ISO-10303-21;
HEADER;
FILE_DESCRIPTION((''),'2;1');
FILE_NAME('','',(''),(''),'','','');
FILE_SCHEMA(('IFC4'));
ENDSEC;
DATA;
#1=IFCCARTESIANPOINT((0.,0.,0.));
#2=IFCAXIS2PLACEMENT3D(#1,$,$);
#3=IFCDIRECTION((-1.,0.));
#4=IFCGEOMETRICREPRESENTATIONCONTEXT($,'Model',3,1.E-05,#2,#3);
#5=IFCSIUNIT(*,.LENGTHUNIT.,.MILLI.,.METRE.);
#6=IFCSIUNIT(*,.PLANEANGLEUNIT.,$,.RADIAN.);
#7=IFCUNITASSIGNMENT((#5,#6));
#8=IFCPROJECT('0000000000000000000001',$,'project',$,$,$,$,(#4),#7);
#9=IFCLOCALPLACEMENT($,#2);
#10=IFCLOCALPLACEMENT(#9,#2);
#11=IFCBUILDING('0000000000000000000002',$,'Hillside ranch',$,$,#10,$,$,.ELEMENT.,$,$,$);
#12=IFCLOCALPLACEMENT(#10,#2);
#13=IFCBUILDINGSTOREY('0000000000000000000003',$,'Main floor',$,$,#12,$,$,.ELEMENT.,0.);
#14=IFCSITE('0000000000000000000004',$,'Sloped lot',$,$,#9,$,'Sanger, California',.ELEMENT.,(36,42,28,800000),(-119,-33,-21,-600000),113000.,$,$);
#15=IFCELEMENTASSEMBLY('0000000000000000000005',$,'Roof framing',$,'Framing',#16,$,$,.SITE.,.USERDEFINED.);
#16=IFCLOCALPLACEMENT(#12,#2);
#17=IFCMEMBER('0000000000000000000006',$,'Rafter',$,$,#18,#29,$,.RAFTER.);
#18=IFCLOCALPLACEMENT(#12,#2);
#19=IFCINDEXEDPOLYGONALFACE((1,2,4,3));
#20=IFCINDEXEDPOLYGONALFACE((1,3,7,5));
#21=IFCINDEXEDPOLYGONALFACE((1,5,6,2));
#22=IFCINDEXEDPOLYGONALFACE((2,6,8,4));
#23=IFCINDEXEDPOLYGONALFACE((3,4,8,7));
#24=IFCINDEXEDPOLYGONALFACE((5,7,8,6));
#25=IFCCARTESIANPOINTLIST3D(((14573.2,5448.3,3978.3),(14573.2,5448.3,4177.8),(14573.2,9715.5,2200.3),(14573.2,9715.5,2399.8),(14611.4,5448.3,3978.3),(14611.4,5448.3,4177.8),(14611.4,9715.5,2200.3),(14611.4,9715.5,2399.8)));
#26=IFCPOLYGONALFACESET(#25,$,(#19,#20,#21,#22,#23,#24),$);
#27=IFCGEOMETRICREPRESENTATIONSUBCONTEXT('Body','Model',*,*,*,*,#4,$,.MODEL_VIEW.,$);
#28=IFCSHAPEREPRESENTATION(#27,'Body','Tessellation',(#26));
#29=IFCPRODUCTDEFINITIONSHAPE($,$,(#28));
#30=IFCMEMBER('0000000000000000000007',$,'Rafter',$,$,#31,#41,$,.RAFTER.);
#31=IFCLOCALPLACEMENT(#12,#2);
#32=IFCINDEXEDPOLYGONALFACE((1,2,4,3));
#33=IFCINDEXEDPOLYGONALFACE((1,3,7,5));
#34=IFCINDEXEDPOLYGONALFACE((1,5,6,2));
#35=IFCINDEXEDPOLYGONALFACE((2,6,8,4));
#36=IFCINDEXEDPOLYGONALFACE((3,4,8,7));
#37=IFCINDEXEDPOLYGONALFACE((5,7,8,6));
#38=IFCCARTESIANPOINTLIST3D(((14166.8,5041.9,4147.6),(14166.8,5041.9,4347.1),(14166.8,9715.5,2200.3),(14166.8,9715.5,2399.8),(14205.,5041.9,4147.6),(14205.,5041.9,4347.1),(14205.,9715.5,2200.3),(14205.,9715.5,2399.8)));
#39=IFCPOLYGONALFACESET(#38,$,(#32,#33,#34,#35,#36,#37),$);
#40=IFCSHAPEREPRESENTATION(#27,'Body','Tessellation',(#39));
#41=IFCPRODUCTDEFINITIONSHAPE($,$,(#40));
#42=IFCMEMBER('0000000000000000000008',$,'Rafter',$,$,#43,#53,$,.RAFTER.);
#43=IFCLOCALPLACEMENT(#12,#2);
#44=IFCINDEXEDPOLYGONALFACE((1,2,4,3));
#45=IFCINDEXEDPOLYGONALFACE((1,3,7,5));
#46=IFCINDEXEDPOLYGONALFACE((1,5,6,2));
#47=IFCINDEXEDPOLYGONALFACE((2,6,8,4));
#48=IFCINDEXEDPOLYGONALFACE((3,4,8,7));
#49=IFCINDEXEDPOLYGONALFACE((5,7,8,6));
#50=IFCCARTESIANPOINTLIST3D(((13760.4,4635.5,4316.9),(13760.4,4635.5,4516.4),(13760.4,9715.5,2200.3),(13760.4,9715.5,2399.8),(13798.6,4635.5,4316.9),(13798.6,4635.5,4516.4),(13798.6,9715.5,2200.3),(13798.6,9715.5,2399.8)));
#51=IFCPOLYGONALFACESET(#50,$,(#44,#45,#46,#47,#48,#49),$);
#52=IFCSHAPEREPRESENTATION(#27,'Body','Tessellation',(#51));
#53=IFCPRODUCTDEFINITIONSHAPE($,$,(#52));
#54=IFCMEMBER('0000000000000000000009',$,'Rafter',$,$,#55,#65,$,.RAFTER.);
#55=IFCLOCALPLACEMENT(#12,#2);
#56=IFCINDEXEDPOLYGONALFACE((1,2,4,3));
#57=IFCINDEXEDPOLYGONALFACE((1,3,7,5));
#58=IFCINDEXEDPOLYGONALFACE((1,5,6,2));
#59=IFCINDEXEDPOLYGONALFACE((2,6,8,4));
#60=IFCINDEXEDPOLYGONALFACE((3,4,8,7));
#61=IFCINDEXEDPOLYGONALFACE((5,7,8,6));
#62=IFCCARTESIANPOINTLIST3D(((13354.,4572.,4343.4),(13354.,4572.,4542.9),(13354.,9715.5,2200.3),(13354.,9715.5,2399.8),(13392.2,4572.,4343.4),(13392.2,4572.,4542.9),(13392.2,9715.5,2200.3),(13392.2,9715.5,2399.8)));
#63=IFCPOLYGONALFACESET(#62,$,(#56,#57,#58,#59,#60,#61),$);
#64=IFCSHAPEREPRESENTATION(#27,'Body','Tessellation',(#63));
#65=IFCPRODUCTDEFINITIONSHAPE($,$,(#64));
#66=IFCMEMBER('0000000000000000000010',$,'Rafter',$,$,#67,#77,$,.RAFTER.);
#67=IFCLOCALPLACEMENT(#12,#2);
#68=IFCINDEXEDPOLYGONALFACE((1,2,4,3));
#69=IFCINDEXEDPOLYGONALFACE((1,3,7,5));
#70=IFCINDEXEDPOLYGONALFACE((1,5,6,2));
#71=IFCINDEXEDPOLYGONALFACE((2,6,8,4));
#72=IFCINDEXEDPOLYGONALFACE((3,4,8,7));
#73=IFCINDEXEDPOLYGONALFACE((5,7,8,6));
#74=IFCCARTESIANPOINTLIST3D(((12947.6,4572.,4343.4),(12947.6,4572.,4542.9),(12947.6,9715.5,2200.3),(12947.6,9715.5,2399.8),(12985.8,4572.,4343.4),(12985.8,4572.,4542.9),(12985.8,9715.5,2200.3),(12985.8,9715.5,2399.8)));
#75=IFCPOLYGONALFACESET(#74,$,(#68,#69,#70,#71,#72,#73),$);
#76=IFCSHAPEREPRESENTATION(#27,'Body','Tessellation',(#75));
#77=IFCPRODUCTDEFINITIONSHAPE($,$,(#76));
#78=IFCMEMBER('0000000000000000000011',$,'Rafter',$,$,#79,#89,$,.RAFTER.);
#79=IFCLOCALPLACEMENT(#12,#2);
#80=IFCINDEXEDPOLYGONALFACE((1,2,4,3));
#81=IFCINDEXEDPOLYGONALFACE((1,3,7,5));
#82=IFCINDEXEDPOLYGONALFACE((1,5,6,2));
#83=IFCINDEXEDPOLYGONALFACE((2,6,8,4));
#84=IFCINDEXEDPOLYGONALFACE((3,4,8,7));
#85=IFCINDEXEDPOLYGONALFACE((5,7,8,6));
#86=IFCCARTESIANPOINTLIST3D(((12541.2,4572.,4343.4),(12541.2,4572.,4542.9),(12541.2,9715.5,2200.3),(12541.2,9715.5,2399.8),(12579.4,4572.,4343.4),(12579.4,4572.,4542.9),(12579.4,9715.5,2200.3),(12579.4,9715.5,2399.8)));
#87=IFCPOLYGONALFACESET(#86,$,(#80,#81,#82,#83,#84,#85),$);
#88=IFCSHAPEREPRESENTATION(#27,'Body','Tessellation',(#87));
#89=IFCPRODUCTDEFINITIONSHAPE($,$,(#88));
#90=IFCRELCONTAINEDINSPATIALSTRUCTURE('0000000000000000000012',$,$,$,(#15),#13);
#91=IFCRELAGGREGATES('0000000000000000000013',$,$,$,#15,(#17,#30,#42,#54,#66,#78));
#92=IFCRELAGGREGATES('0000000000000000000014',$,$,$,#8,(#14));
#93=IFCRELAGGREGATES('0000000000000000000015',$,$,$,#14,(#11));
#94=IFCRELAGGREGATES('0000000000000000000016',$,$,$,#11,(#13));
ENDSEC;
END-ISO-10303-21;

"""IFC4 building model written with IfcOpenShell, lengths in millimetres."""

from ifc_helpers import new_model, si_unit, direction, frame, origin, origin_with_axes, place, context, subcontext, project, spatial, polyline, outline, extrude, element, aggregate, save


model = new_model("IFC4")

# Units and contexts
model_context = context("Model", 3, precision=1e-05, world=origin(), true_north=direction((-1.0, 0.0)))
body_context = subcontext(model_context, "Body", "Model", "MODEL_VIEW")
ifc_project = project(units=[si_unit("LENGTHUNIT", "METRE", prefix="MILLI"), si_unit("PLANEANGLEUNIT", "RADIAN")], contexts=[model_context])

# Site, building, storey
site_placement = place(None, origin())
site = spatial("IfcSite", under=ifc_project, at=site_placement, Name="Sloped lot", LongName="Sanger, California", CompositionType="ELEMENT", RefLatitude=(36, 42, 28, 800000), RefLongitude=(-119, -33, -21, -600000), RefElevation=113000.0)
building_placement = place(site_placement, origin())
building = spatial("IfcBuilding", under=site, at=building_placement, Name="Hillside ranch", CompositionType="ELEMENT")
storey_placement = place(building_placement, origin())
storey = spatial("IfcBuildingStorey", under=building, at=storey_placement, Name="Main floor", CompositionType="ELEMENT", Elevation=0.0)

# Element assembly, members
assembly_1_placement = place(storey_placement, origin_with_axes())
assembly_1 = element("IfcElementAssembly", 1, at=assembly_1_placement, inside=storey, Name="Roof framing", ObjectType="Framing", AssemblyPlace="SITE", PredefinedType="USERDEFINED")
member_1_placement = place(storey_placement, origin_with_axes())
member_1 = element("IfcMember", 2, at=member_1_placement, Name="Rafter", PredefinedType="RAFTER", context=body_context, shape_type="SweptSolid", body=[
    extrude(outline(polyline([(0.0, 0.0), (38.1, 0.0), (38.1, 199.5), (0.0, 199.5), (0.0, 0.0)])), frame((14573.2, 9715.5, 2200.3), z_axis=(0.0, -1.0, 0.0), x_axis=(1.0, 0.0, 0.0)), (0.0, 0.384615, 0.923077), 4622.8),
])
member_2_placement = place(storey_placement, origin_with_axes())
member_2 = element("IfcMember", 3, at=member_2_placement, Name="Rafter", PredefinedType="RAFTER", context=body_context, shape_type="SweptSolid", body=[
    extrude(outline(polyline([(0.0, 0.0), (38.1, 0.0), (38.1, 199.5), (0.0, 199.5), (0.0, 0.0)])), frame((14166.9, 9715.5, 2200.3), z_axis=(0.0, -1.0, 0.0), x_axis=(1.0, 0.0, 0.0)), (0.0, 0.384615, 0.923077), 5063.1),
])
member_3_placement = place(storey_placement, origin_with_axes())
member_3 = element("IfcMember", 4, at=member_3_placement, Name="Rafter", PredefinedType="RAFTER", context=body_context, shape_type="SweptSolid", body=[
    extrude(outline(polyline([(0.0, 0.0), (38.1, 0.0), (38.1, 199.5), (0.0, 199.5), (0.0, 0.0)])), frame((13760.5, 9715.5, 2200.3), z_axis=(0.0, -1.0, 0.0), x_axis=(1.0, 0.0, 0.0)), (0.0, 0.384615, 0.923077), 5503.3),
])
member_4_placement = place(storey_placement, origin_with_axes())
member_4 = element("IfcMember", 5, at=member_4_placement, Name="Rafter", PredefinedType="RAFTER", context=body_context, shape_type="SweptSolid", body=[
    extrude(outline(polyline([(0.0, 0.0), (38.1, 0.0), (38.1, 199.5), (0.0, 199.5), (0.0, 0.0)])), frame((13354.0, 9715.5, 2200.3), z_axis=(0.0, -1.0, 0.0), x_axis=(1.0, 0.0, 0.0)), (0.0, 0.384615, 0.923077), 5572.1),
])
member_5_placement = place(storey_placement, origin_with_axes())
member_5 = element("IfcMember", 6, at=member_5_placement, Name="Rafter", PredefinedType="RAFTER", context=body_context, shape_type="SweptSolid", body=[
    extrude(outline(polyline([(0.0, 0.0), (38.1, 0.0), (38.1, 199.5), (0.0, 199.5), (0.0, 0.0)])), frame((12947.6, 9715.5, 2200.3), z_axis=(0.0, -1.0, 0.0), x_axis=(1.0, 0.0, 0.0)), (0.0, 0.384615, 0.923077), 5572.1),
])
member_6_placement = place(storey_placement, origin_with_axes())
member_6 = element("IfcMember", 7, at=member_6_placement, Name="Rafter", PredefinedType="RAFTER", context=body_context, shape_type="SweptSolid", body=[
    extrude(outline(polyline([(0.0, 0.0), (38.1, 0.0), (38.1, 199.5), (0.0, 199.5), (0.0, 0.0)])), frame((12541.2, 9715.5, 2200.3), z_axis=(0.0, -1.0, 0.0), x_axis=(1.0, 0.0, 0.0)), (0.0, 0.384615, 0.923077), 5572.1),
])
aggregate(assembly_1, [member_1, member_2, member_3, member_4, member_5, member_6])

save(model, "model.ifc")
